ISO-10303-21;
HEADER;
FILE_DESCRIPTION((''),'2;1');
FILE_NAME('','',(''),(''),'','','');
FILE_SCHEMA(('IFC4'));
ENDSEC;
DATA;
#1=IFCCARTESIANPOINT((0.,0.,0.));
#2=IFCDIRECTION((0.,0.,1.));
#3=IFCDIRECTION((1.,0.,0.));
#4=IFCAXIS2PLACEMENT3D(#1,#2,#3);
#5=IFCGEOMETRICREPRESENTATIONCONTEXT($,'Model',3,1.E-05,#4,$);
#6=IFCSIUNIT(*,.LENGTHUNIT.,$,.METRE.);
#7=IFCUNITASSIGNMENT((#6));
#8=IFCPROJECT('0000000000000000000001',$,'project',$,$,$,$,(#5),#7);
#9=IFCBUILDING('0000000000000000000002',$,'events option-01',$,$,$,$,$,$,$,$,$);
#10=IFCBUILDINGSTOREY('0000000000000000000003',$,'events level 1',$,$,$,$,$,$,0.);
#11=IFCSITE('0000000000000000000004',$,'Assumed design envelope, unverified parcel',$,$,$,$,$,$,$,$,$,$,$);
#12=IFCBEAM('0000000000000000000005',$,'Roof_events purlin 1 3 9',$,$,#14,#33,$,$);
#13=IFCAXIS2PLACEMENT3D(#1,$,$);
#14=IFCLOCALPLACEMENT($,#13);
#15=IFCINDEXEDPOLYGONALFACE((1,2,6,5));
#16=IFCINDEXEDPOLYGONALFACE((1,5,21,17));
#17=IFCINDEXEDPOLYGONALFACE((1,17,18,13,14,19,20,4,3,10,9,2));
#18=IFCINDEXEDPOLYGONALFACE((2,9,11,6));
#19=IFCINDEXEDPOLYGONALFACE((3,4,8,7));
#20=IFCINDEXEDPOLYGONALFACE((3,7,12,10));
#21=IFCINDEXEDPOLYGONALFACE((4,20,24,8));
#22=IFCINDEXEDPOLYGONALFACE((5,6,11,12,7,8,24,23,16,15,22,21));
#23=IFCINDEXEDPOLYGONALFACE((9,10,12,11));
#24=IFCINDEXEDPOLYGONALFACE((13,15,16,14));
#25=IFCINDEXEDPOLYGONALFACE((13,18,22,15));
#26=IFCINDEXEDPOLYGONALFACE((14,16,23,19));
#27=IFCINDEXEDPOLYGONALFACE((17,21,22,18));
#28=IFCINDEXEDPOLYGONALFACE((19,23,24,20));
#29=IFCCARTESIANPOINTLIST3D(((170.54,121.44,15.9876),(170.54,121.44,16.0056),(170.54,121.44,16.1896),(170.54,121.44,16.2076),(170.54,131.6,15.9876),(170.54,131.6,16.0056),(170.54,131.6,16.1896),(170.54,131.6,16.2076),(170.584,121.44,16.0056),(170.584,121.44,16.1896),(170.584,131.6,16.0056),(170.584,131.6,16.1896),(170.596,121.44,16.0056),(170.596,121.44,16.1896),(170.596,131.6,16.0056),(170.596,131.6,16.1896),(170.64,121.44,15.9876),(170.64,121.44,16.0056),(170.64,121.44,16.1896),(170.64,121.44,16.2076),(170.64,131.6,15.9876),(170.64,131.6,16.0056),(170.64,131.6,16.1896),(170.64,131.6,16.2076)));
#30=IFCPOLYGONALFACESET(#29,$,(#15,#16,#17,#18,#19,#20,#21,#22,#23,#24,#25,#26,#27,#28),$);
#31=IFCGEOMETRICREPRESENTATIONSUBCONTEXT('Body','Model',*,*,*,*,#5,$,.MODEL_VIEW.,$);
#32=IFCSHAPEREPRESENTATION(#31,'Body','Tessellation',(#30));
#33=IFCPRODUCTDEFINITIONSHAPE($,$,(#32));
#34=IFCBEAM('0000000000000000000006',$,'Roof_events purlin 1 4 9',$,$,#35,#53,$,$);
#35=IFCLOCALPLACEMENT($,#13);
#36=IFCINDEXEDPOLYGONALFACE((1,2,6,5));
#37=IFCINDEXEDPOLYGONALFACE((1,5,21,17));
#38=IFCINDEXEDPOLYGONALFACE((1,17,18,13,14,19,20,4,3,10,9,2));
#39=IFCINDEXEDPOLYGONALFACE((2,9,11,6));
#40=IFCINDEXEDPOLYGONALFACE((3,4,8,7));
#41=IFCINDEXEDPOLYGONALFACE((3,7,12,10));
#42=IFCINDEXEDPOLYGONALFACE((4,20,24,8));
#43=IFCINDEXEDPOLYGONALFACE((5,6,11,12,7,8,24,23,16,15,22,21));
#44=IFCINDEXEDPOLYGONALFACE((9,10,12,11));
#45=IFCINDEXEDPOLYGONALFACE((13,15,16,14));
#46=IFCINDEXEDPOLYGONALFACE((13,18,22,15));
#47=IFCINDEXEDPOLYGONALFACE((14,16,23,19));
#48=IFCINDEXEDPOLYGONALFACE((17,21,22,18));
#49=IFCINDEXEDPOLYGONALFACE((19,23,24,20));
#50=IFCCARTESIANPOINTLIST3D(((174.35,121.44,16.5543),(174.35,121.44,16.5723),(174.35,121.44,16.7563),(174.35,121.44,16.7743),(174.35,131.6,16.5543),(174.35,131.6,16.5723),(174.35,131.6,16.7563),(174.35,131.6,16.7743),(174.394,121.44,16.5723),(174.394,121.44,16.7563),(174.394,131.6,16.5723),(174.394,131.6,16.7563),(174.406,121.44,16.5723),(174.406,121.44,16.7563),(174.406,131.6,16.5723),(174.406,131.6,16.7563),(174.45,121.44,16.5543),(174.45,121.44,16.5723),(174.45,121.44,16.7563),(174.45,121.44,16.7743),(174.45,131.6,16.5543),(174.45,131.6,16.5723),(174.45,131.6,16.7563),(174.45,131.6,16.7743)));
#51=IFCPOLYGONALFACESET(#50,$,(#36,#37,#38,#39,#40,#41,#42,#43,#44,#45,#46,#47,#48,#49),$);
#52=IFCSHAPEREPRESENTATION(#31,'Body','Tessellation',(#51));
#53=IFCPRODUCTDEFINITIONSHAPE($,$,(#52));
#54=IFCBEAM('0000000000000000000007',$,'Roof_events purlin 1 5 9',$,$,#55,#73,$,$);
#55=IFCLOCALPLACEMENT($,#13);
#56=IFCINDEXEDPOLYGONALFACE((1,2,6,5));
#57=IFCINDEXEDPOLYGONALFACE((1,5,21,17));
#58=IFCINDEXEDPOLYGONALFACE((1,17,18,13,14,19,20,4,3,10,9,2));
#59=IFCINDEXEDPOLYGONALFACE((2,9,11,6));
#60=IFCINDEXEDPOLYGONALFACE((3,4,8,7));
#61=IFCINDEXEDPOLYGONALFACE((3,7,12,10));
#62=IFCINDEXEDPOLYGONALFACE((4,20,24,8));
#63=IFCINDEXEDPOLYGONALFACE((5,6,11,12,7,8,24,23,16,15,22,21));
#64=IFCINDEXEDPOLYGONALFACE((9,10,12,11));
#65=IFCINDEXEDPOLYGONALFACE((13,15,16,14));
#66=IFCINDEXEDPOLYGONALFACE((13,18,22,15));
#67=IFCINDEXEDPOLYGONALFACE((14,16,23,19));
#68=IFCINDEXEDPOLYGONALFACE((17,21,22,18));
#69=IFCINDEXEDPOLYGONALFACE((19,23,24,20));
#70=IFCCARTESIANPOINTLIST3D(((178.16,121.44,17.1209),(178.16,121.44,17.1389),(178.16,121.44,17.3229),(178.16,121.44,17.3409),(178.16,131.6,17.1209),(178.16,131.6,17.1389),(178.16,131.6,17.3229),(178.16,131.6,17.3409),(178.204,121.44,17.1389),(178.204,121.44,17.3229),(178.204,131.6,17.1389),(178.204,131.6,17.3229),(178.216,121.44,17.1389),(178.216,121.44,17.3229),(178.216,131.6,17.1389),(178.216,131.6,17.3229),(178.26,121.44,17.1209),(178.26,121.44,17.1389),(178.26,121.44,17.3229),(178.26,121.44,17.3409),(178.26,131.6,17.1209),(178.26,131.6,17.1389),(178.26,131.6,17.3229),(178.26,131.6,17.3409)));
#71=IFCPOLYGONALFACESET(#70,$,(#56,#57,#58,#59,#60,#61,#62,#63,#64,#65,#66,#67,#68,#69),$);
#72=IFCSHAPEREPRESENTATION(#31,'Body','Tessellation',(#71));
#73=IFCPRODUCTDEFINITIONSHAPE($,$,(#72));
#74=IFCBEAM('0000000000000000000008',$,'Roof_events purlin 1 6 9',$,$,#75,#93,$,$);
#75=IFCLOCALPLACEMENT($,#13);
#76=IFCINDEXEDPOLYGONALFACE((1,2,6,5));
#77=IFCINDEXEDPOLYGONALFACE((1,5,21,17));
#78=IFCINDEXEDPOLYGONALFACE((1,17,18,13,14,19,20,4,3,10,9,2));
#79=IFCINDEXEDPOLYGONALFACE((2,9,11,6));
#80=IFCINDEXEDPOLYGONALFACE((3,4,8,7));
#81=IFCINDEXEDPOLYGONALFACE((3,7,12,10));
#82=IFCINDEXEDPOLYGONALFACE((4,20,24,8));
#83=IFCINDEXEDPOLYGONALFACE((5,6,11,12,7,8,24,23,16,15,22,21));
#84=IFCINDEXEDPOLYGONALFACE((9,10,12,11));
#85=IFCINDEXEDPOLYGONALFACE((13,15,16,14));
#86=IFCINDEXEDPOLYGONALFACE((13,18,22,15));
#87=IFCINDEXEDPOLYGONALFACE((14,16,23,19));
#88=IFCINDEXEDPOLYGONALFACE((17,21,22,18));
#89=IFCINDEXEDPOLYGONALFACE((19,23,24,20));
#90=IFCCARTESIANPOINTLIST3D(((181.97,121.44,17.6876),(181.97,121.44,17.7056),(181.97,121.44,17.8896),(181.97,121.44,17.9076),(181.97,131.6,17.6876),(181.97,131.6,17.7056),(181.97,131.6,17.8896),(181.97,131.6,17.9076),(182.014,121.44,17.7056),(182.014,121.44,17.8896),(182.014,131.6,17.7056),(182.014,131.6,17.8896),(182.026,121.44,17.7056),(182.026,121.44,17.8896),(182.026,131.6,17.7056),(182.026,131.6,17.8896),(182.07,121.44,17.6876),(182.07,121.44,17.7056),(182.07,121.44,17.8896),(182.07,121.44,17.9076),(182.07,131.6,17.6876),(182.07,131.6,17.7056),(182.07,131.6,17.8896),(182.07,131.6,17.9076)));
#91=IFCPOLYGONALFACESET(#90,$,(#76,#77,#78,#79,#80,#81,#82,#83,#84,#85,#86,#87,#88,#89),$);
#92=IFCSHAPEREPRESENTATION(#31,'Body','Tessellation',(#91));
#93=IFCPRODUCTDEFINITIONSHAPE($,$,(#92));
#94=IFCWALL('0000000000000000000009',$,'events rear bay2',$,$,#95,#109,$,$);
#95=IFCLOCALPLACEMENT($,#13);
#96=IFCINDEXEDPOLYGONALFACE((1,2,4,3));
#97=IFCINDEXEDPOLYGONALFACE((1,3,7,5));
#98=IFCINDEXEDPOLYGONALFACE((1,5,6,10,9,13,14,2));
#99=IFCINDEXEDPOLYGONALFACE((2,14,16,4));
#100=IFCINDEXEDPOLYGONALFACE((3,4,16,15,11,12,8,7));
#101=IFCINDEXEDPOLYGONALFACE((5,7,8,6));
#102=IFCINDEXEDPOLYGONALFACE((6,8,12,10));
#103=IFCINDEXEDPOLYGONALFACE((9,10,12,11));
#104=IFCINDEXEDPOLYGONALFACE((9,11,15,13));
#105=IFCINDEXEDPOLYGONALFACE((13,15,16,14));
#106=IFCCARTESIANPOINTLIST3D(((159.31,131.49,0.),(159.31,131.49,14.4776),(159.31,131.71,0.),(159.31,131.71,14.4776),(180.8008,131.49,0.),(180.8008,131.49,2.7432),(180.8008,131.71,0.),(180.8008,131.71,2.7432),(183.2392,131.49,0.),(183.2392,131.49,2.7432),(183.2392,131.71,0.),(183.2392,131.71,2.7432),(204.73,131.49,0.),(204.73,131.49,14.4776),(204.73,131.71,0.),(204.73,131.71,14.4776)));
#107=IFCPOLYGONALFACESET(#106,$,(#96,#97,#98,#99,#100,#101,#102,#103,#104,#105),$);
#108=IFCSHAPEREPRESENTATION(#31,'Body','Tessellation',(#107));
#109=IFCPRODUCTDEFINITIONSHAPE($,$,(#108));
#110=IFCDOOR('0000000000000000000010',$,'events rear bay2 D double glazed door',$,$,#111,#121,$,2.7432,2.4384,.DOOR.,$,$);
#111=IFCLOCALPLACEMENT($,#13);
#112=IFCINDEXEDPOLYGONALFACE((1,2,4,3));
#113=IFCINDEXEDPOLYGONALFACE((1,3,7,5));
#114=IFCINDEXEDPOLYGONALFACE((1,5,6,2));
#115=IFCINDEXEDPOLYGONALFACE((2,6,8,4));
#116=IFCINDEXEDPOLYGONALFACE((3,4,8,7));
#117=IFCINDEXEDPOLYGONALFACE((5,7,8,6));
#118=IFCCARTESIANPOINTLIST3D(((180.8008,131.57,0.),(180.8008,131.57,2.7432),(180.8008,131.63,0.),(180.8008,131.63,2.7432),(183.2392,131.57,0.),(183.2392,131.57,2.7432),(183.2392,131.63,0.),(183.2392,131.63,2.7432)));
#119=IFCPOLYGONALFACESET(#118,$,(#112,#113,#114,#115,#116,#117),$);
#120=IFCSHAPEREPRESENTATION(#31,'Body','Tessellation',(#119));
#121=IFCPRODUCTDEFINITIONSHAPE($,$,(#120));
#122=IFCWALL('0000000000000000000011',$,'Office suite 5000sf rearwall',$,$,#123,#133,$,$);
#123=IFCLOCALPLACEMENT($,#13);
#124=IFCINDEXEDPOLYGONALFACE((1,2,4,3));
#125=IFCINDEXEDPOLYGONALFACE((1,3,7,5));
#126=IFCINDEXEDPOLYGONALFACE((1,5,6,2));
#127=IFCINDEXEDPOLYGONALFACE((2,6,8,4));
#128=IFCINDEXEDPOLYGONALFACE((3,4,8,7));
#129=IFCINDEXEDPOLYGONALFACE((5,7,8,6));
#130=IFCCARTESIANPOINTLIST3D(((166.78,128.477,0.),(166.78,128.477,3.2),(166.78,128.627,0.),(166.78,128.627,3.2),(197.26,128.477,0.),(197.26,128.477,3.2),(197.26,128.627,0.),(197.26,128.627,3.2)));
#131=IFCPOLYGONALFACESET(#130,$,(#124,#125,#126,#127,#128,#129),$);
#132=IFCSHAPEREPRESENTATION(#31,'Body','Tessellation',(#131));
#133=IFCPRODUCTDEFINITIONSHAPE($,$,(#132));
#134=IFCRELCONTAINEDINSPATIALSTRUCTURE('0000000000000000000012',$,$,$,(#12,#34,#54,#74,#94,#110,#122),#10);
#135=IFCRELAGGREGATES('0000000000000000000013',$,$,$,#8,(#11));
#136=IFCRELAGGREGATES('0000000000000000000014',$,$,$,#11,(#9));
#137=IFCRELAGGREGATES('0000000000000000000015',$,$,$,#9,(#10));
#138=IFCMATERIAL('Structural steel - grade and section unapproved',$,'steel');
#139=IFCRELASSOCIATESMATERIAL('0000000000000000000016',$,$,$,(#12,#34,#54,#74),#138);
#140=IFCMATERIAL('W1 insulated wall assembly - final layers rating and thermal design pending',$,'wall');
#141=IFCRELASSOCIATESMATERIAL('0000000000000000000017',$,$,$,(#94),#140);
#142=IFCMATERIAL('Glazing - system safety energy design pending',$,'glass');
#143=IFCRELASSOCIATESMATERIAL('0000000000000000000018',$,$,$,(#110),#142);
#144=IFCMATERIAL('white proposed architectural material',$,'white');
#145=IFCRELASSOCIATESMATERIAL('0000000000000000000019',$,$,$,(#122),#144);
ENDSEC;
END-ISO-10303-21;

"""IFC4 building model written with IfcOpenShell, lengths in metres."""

from ifc_helpers import new_model, si_unit, frame, origin_with_axes, place, context, subcontext, project, spatial, rectangle, i_section, extrude, material, element, fill, save


model = new_model("IFC4")

# Units and contexts
model_context = context("Model", 3, precision=1e-05, world=origin_with_axes())
body_context = subcontext(model_context, "Body", "Model", "MODEL_VIEW")
ifc_project = project(units=[si_unit("LENGTHUNIT", "METRE")], contexts=[model_context])

# Site, building, storey
site = spatial("IfcSite", under=ifc_project, Name="Assumed design envelope, unverified parcel")
building = spatial("IfcBuilding", under=site, Name="events option-01")
storey = spatial("IfcBuildingStorey", under=building, Name="events level 1", Elevation=0.0)

# Beams
ifc_material_1 = material(Name="Structural steel - grade and section unapproved", Category="steel")
for number, where, z_axis, x_axis, name in (
    (1, (170.59, 121.44, 16.0976), (0.0, 1.0, 0.0), (-1.0, 0.0, 0.0), "Roof_events purlin 1 3 9"),
    (2, (174.4, 121.44, 16.6643), (0.0, 1.0, 0.0), (-1.0, 0.0, 0.0), "Roof_events purlin 1 4 9"),
    (3, (178.21, 121.44, 17.2309), (0.0, 1.0, 0.0), (-1.0, 0.0, 0.0), "Roof_events purlin 1 5 9"),
    (4, (182.02, 121.44, 17.7976), (0.0, 1.0, 0.0), (-1.0, 0.0, 0.0), "Roof_events purlin 1 6 9"),
):
    element("IfcBeam", number, at=place(None, frame(where, z_axis=z_axis, x_axis=x_axis)), inside=storey, material=ifc_material_1, Name=name, context=body_context, shape_type="SweptSolid", body=[
        extrude(i_section(OverallWidth=0.1, OverallDepth=0.22, WebThickness=0.012, FlangeThickness=0.018, FilletRadius=0.0), origin_with_axes(), (0.0, 0.0, 1.0), 10.16),
    ])

# Wall, opening, door
ifc_material_2 = material(Name="W1 insulated wall assembly - final layers rating and thermal design pending", Category="wall")
wall_1_placement = place(None, frame((182.02, 131.6, 0.0), z_axis=(0.0, 0.0, 1.0), x_axis=(1.0, 0.0, 0.0)))
wall_1 = element("IfcWall", 5, at=wall_1_placement, inside=storey, material=ifc_material_2, Name="events rear bay2", context=body_context, shape_type="SweptSolid", body=[
    extrude(rectangle(XDim=45.42, YDim=0.22), origin_with_axes(), (0.0, 0.0, 1.0), 14.4776),
])
opening_placement = place(None, frame((182.02, 131.6, 0.0), z_axis=(0.0, 0.0, 1.0), x_axis=(1.0, 0.0, 0.0)))
opening = element("IfcOpeningElement", 6, at=opening_placement, cuts=wall_1, context=body_context, shape_type="SweptSolid", body=[
    extrude(rectangle(XDim=2.4384, YDim=0.32), origin_with_axes(), (0.0, 0.0, 1.0), 2.7432),
])
ifc_material_3 = material(Name="Glazing - system safety energy design pending", Category="glass")
door_placement = place(None, frame((182.02, 131.6, 0.0), z_axis=(0.0, 0.0, 1.0), x_axis=(1.0, 0.0, 0.0)))
door = element("IfcDoor", 7, at=door_placement, inside=storey, material=ifc_material_3, Name="events rear bay2 D double glazed door", OverallHeight=2.7432, OverallWidth=2.4384, PredefinedType="DOOR", context=body_context, shape_type="SweptSolid", body=[
    extrude(rectangle(XDim=2.4384, YDim=0.06), origin_with_axes(), (0.0, 0.0, 1.0), 2.7432),
])
fill(opening, door)

# Wall
ifc_material_4 = material(Name="white proposed architectural material", Category="white")
wall_2_placement = place(None, frame((182.02, 128.552, 0.0), z_axis=(0.0, 0.0, 1.0), x_axis=(1.0, 0.0, 0.0)))
element("IfcWall", 8, at=wall_2_placement, inside=storey, material=ifc_material_4, Name="Office suite 5000sf rearwall", context=body_context, shape_type="SweptSolid", body=[
    extrude(rectangle(XDim=30.48, YDim=0.15), origin_with_axes(), (0.0, 0.0, 1.0), 3.2),
])

save(model, "model.ifc")
